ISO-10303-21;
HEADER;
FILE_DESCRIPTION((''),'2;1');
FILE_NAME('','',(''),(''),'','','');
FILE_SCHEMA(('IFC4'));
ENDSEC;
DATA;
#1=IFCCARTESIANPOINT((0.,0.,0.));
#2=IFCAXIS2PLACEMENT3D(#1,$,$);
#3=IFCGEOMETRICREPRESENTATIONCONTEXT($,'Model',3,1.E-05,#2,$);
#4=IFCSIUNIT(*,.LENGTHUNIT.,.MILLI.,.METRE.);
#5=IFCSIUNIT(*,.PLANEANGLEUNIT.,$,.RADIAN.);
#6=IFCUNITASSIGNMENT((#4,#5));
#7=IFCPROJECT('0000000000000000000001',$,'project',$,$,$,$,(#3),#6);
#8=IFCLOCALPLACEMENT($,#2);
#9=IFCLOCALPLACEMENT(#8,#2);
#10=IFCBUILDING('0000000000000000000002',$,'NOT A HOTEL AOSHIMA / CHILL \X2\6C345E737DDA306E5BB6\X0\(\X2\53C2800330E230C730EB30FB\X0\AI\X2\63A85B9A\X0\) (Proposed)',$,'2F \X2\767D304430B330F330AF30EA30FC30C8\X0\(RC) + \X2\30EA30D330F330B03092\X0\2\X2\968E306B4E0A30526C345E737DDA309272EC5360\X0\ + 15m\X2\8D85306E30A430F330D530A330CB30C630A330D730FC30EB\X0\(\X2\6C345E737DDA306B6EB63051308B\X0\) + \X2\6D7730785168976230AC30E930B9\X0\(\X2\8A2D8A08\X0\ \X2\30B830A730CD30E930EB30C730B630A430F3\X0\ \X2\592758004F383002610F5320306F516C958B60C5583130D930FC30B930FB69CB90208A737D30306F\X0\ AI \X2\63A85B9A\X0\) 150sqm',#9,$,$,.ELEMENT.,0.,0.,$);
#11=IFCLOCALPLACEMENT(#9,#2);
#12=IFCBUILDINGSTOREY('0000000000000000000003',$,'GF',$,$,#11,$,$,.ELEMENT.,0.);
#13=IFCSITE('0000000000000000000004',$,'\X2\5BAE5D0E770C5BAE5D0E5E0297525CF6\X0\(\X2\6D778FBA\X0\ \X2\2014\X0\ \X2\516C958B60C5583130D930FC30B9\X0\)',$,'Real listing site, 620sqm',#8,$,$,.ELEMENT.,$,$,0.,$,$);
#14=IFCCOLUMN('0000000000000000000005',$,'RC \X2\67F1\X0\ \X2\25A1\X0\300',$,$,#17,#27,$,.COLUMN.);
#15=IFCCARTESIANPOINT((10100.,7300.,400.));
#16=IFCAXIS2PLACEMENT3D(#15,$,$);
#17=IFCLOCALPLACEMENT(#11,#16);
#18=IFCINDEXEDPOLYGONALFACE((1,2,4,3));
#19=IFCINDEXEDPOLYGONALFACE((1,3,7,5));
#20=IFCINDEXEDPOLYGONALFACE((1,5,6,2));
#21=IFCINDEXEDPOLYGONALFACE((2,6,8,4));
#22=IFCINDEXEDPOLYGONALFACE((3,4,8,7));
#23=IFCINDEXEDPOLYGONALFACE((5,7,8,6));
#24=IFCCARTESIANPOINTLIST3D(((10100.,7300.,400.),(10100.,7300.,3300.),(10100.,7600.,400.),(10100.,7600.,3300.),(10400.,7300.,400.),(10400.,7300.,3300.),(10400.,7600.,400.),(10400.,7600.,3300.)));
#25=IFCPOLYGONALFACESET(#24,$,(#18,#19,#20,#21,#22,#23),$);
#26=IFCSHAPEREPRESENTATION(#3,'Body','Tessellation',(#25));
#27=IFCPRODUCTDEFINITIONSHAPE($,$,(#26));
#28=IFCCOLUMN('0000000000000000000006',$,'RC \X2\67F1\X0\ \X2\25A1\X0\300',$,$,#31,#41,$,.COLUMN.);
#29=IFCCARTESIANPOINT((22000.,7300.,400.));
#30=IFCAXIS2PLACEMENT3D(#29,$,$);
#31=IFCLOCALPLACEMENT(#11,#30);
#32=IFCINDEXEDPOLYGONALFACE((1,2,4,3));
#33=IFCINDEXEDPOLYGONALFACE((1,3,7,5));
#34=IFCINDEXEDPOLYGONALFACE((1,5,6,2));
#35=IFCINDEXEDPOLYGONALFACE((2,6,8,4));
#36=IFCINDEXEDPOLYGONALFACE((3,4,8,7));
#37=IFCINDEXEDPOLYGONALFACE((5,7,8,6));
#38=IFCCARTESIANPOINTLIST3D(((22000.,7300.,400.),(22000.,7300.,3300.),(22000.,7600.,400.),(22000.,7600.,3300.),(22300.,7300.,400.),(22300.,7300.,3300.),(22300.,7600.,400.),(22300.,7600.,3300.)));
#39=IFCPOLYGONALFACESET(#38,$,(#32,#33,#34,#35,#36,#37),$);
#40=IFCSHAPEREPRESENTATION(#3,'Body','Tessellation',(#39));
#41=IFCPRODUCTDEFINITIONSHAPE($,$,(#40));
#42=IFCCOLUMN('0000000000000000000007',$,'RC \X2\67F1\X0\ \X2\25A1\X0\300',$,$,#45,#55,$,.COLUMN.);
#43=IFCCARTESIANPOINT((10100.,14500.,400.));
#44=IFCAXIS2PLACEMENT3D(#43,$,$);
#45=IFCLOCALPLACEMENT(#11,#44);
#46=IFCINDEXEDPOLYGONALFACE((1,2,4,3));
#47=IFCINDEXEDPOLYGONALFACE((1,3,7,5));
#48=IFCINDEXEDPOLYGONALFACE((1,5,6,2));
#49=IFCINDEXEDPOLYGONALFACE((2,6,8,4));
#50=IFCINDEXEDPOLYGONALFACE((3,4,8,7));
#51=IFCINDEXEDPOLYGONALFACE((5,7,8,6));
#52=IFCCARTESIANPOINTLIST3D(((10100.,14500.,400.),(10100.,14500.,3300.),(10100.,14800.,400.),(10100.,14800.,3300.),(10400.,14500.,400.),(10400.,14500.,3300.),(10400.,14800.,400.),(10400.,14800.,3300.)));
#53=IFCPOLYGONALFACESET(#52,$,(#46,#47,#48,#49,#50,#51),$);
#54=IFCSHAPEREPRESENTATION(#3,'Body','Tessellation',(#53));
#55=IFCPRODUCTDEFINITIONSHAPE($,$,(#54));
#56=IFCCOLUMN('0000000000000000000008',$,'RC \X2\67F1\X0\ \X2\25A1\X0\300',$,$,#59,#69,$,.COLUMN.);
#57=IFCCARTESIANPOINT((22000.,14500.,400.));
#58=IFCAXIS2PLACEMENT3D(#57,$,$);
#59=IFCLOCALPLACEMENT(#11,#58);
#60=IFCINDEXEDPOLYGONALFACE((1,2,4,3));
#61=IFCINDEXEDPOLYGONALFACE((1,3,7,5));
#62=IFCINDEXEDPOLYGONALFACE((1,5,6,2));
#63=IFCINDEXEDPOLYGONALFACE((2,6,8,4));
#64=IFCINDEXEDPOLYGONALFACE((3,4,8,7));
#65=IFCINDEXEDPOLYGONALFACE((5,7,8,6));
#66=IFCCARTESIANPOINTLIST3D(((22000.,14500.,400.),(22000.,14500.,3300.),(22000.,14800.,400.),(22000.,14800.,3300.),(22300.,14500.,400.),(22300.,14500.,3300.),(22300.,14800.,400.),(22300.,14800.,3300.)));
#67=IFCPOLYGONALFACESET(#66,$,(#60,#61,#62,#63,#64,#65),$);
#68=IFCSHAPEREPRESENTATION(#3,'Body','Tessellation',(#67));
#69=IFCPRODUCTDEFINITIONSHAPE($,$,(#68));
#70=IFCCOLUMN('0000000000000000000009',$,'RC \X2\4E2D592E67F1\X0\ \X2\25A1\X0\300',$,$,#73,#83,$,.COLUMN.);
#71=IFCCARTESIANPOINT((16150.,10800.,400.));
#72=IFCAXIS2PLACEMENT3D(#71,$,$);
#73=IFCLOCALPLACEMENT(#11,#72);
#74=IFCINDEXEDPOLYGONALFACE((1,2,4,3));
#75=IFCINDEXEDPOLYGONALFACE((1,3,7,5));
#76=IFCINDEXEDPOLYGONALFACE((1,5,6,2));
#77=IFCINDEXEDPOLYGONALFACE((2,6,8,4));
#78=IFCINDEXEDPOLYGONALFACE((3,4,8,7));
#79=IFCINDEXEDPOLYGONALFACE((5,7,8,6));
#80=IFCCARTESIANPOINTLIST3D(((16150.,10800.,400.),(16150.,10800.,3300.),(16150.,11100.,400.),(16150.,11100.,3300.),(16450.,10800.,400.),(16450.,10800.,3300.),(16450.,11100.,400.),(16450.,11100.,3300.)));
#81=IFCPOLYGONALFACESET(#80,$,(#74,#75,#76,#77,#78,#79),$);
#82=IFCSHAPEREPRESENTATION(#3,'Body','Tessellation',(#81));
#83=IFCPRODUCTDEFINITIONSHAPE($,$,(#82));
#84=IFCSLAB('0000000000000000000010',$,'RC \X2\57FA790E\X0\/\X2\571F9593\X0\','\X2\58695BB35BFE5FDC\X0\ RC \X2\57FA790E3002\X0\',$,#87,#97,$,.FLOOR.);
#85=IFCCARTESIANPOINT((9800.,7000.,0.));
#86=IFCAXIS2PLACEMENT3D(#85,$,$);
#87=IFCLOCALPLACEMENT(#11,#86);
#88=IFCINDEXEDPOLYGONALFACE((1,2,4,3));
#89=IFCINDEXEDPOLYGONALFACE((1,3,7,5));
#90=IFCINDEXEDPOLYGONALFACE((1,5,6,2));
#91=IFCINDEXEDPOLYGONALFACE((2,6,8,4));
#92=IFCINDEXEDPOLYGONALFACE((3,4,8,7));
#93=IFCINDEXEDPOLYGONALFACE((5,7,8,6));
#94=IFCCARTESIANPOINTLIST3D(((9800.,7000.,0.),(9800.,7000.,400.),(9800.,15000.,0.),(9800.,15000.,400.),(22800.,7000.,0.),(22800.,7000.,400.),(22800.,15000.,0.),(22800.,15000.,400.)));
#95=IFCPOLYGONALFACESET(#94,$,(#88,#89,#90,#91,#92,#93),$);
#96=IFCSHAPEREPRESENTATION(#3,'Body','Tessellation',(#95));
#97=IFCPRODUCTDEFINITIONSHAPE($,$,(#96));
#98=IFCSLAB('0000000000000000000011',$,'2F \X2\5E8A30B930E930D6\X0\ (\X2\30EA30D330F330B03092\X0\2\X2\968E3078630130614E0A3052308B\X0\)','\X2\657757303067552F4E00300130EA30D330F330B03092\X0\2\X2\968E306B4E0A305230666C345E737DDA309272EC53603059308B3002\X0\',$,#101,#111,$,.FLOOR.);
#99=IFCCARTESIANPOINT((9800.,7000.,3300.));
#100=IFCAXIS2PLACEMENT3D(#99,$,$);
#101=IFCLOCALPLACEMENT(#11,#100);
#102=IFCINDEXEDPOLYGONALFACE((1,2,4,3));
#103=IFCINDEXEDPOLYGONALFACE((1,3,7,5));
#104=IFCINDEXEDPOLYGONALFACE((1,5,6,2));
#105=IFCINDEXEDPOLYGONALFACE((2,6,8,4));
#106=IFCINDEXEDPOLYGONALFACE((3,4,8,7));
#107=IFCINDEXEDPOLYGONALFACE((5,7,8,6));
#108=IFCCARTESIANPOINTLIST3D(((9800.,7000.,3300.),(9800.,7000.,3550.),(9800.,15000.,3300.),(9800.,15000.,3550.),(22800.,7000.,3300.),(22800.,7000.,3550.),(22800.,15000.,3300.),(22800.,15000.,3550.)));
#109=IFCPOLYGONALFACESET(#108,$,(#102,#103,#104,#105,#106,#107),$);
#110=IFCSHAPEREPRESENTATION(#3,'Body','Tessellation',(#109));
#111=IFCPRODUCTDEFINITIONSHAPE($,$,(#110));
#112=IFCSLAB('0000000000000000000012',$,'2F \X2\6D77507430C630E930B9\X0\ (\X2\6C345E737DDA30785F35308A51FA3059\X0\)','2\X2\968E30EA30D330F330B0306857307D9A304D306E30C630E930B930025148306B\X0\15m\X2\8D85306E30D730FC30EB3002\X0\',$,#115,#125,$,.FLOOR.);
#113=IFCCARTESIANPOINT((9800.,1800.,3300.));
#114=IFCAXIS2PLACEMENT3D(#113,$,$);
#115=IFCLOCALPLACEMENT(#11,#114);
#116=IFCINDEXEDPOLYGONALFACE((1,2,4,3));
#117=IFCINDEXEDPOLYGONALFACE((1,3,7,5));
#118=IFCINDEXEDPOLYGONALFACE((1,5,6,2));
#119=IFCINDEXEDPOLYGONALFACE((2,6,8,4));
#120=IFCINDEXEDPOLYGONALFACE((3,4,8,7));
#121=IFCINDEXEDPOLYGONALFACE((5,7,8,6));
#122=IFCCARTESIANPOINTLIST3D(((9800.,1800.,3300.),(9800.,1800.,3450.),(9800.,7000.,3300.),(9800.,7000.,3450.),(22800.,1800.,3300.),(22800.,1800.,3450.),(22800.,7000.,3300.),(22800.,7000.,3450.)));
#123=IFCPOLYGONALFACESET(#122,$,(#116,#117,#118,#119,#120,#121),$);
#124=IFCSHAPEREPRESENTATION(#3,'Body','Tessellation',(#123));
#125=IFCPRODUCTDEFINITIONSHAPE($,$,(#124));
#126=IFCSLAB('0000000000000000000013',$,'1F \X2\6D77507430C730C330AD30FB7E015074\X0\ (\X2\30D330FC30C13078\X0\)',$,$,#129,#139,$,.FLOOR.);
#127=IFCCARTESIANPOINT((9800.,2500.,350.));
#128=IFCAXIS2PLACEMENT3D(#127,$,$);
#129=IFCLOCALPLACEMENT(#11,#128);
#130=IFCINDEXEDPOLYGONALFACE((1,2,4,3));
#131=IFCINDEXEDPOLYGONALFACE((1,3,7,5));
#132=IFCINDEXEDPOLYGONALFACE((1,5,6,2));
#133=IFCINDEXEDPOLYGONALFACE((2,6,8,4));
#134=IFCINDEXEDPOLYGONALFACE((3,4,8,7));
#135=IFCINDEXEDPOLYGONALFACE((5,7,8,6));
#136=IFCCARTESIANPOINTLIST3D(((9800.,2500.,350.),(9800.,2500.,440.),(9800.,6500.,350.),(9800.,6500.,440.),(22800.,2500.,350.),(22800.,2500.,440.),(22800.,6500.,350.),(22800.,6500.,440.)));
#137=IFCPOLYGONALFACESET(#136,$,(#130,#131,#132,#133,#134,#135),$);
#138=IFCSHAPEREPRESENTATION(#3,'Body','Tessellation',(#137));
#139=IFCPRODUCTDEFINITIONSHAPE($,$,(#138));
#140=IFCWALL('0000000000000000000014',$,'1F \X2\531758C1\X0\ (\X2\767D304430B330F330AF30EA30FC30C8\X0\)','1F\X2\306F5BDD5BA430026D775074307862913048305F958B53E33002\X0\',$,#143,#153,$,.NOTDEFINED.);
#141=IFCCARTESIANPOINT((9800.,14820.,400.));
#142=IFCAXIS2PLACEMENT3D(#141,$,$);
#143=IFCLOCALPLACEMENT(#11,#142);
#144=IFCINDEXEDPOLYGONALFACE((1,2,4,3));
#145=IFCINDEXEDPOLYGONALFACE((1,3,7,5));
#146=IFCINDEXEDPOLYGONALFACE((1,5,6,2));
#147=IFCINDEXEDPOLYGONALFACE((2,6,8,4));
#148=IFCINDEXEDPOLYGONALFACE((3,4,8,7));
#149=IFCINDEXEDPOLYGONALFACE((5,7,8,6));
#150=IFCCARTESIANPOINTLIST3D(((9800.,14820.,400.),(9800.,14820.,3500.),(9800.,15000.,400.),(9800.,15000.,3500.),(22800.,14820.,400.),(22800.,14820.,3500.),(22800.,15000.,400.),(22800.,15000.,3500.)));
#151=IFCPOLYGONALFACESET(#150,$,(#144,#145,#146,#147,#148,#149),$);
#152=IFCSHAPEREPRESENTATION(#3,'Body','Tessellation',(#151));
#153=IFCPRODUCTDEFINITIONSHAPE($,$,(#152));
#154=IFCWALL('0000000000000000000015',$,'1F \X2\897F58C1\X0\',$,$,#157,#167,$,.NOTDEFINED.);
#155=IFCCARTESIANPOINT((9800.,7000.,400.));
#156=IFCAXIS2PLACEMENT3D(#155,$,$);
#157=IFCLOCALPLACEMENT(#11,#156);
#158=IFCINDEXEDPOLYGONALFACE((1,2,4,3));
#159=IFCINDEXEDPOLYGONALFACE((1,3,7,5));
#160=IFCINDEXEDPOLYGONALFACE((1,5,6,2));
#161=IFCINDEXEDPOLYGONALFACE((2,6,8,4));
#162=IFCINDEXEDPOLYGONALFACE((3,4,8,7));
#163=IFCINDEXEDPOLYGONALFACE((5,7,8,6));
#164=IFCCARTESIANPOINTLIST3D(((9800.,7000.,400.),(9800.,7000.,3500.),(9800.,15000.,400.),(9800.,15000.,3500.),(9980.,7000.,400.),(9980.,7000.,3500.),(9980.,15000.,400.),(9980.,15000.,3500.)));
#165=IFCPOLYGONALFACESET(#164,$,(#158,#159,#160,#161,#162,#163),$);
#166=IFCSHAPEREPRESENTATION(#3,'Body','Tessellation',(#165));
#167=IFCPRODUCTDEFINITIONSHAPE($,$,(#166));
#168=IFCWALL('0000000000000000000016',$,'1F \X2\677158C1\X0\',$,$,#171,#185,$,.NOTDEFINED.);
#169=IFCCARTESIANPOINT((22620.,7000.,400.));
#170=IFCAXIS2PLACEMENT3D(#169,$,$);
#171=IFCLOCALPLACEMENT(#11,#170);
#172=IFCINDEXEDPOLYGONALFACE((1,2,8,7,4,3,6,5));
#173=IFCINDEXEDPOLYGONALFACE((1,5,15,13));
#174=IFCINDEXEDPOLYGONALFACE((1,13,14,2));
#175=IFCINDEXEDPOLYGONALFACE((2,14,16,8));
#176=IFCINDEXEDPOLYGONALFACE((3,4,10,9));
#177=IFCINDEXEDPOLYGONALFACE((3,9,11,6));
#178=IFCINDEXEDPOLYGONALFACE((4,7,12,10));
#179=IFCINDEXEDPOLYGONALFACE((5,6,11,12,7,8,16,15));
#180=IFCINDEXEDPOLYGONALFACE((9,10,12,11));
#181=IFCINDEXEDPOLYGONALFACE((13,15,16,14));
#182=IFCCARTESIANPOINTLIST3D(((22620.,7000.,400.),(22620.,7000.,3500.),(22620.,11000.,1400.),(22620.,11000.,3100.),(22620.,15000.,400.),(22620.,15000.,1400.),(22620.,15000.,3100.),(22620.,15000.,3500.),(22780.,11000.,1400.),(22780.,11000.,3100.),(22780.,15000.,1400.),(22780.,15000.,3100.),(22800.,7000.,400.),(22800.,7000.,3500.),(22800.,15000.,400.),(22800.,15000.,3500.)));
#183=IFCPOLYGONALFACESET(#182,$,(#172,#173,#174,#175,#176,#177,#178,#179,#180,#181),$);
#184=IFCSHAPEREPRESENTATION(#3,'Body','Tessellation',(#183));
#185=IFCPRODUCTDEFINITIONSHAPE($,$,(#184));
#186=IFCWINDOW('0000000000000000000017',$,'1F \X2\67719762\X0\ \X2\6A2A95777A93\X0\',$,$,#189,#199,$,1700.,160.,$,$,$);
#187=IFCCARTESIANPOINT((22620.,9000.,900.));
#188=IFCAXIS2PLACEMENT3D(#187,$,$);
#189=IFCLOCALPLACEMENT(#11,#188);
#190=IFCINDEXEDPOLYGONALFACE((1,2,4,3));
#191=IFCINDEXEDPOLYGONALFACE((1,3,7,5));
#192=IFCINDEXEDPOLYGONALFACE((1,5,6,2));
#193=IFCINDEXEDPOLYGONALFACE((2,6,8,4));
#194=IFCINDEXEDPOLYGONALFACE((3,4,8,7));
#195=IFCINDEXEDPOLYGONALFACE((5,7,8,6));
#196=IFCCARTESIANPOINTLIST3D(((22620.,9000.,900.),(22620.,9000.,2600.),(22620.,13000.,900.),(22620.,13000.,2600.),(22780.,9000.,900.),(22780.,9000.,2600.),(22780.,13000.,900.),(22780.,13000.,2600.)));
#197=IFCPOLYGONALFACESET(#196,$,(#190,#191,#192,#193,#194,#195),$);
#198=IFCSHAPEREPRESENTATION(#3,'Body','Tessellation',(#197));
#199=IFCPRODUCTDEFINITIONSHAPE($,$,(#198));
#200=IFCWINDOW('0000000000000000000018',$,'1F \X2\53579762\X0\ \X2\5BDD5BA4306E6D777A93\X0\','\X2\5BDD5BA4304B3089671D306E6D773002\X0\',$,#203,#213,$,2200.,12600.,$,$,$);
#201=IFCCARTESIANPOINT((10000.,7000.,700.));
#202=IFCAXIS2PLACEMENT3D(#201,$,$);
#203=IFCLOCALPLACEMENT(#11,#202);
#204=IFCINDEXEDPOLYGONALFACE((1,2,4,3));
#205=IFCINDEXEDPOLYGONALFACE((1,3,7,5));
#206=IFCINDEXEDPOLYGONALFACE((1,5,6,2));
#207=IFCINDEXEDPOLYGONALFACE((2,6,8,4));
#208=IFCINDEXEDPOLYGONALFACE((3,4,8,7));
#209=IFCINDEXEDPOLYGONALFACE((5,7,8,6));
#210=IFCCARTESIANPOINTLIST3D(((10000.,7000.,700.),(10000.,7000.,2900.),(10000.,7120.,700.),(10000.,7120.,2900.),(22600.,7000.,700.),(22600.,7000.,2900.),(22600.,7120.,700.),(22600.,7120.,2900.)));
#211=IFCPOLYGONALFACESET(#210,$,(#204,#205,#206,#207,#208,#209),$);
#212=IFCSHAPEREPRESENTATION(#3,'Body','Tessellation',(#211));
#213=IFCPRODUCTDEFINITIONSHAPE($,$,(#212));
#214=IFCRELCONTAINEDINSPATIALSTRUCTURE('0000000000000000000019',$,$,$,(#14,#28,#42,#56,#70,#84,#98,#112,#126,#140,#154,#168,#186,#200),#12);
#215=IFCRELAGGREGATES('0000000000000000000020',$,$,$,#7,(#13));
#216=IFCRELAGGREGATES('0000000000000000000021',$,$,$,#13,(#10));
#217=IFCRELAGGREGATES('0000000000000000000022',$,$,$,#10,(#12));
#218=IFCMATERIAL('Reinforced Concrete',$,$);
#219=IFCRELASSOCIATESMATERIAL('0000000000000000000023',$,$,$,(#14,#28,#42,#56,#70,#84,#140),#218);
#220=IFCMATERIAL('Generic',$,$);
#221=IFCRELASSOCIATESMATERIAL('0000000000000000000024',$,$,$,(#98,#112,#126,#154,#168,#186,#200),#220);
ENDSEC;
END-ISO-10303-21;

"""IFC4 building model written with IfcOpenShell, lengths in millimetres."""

from ifc_helpers import new_model, si_unit, frame, frame_2d, origin, place, context, project, spatial, rectangle, extrude, material, element, fill, save


model = new_model("IFC4")

# Units and contexts
model_context = context("Model", 3, precision=1e-05, world=origin())
ifc_project = project(units=[si_unit("LENGTHUNIT", "METRE", prefix="MILLI"), si_unit("PLANEANGLEUNIT", "RADIAN")], contexts=[model_context])

# Site, building, storey
site_placement = place(None, origin())
site = spatial("IfcSite", under=ifc_project, at=site_placement, Name="宮崎県宮崎市青島(海辺 — 公開情報ベース)", ObjectType="Real listing site, 620sqm", CompositionType="ELEMENT", RefElevation=0.0)
building_placement = place(site_placement, origin())
building = spatial("IfcBuilding", under=site, at=building_placement, Name="NOT A HOTEL AOSHIMA / CHILL 水平線の家(参考モデル・AI推定) (Proposed)", ObjectType="2F 白いコンクリート(RC) + リビングを2階に上げ水平線を独占 + 15m超のインフィニティプール(水平線に溶ける) + 海へ全面ガラス(設計 ジェネラルデザイン 大堀伸。意匠は公開情報ベース・構造詳細は AI 推定) 150sqm", CompositionType="ELEMENT", ElevationOfRefHeight=0.0, ElevationOfTerrain=0.0)
storey_placement = place(building_placement, origin())
storey = spatial("IfcBuildingStorey", under=building, at=storey_placement, Name="GF", CompositionType="ELEMENT", Elevation=0.0)

# Columns
ifc_material_1 = material(Name="Reinforced Concrete")
column_1_placement = place(storey_placement, frame((10100.0, 7300.0, 400.0)))
element("IfcColumn", 1, at=column_1_placement, inside=storey, material=ifc_material_1, Name="RC 柱 □300", PredefinedType="COLUMN", context=model_context, shape_type="SweptSolid", body=[
    extrude(rectangle(XDim=300.0, YDim=300.0, at=frame_2d((150.0, 150.0))), frame((10100.0, 7300.0, 400.0)), (0.0, 0.0, 1.0), 2900.0),
])
column_2_placement = place(storey_placement, frame((22000.0, 7300.0, 400.0)))
element("IfcColumn", 2, at=column_2_placement, inside=storey, material=ifc_material_1, Name="RC 柱 □300", PredefinedType="COLUMN", context=model_context, shape_type="SweptSolid", body=[
    extrude(rectangle(XDim=300.0, YDim=300.0, at=frame_2d((150.0, 150.0))), frame((22000.0, 7300.0, 400.0)), (0.0, 0.0, 1.0), 2900.0),
])
column_3_placement = place(storey_placement, frame((10100.0, 14500.0, 400.0)))
element("IfcColumn", 3, at=column_3_placement, inside=storey, material=ifc_material_1, Name="RC 柱 □300", PredefinedType="COLUMN", context=model_context, shape_type="SweptSolid", body=[
    extrude(rectangle(XDim=300.0, YDim=300.0, at=frame_2d((150.0, 150.0))), frame((10100.0, 14500.0, 400.0)), (0.0, 0.0, 1.0), 2900.0),
])
column_4_placement = place(storey_placement, frame((22000.0, 14500.0, 400.0)))
element("IfcColumn", 4, at=column_4_placement, inside=storey, material=ifc_material_1, Name="RC 柱 □300", PredefinedType="COLUMN", context=model_context, shape_type="SweptSolid", body=[
    extrude(rectangle(XDim=300.0, YDim=300.0, at=frame_2d((150.0, 150.0))), frame((22000.0, 14500.0, 400.0)), (0.0, 0.0, 1.0), 2900.0),
])
column_5_placement = place(storey_placement, frame((16150.0, 10800.0, 400.0)))
element("IfcColumn", 5, at=column_5_placement, inside=storey, material=ifc_material_1, Name="RC 中央柱 □300", PredefinedType="COLUMN", context=model_context, shape_type="SweptSolid", body=[
    extrude(rectangle(XDim=300.0, YDim=300.0, at=frame_2d((150.0, 150.0))), frame((16150.0, 10800.0, 400.0)), (0.0, 0.0, 1.0), 2900.0),
])

# Slabs
slab_1_placement = place(storey_placement, frame((9800.0, 7000.0, 0.0)))
element("IfcSlab", 6, at=slab_1_placement, inside=storey, material=ifc_material_1, Name="RC 基礎/土間", Description="塩害対応 RC 基礎。", PredefinedType="FLOOR", context=model_context, shape_type="SweptSolid", body=[
    extrude(rectangle(XDim=13000.0, YDim=8000.0, at=frame_2d((6500.0, 4000.0))), frame((9800.0, 7000.0, 0.0)), (0.0, 0.0, 1.0), 400.0),
])
ifc_material_2 = material(Name="Generic")
slab_2_placement = place(storey_placement, frame((9800.0, 7000.0, 3300.0)))
element("IfcSlab", 7, at=slab_2_placement, inside=storey, material=ifc_material_2, Name="2F 床スラブ (リビングを2階へ持ち上げる)", Description="敷地で唯一、リビングを2階に上げて水平線を独占する。", PredefinedType="FLOOR", context=model_context, shape_type="SweptSolid", body=[
    extrude(rectangle(XDim=13000.0, YDim=8000.0, at=frame_2d((6500.0, 4000.0))), frame((9800.0, 7000.0, 3300.0)), (0.0, 0.0, 1.0), 250.0),
])
slab_3_placement = place(storey_placement, frame((9800.0, 1800.0, 3300.0)))
element("IfcSlab", 8, at=slab_3_placement, inside=storey, material=ifc_material_2, Name="2F 海側テラス (水平線へ張り出す)", Description="2階リビングと地続きのテラス。先に15m超のプール。", PredefinedType="FLOOR", context=model_context, shape_type="SweptSolid", body=[
    extrude(rectangle(XDim=13000.0, YDim=5200.0, at=frame_2d((6500.0, 2600.0))), frame((9800.0, 1800.0, 3300.0)), (0.0, 0.0, 1.0), 150.0),
])
slab_4_placement = place(storey_placement, frame((9800.0, 2500.0, 350.0)))
element("IfcSlab", 9, at=slab_4_placement, inside=storey, material=ifc_material_2, Name="1F 海側デッキ・縁側 (ビーチへ)", PredefinedType="FLOOR", context=model_context, shape_type="SweptSolid", body=[
    extrude(rectangle(XDim=13000.0, YDim=4000.0, at=frame_2d((6500.0, 2000.0))), frame((9800.0, 2500.0, 350.0)), (0.0, 0.0, 1.0), 90.0),
])

# Walls
wall_1_placement = place(storey_placement, frame((9800.0, 14820.0, 400.0)))
element("IfcWall", 10, at=wall_1_placement, inside=storey, material=ifc_material_1, Name="1F 北壁 (白いコンクリート)", Description="1Fは寝室。海側へ抑えた開口。", PredefinedType="NOTDEFINED", context=model_context, shape_type="SweptSolid", body=[
    extrude(rectangle(XDim=13000.0, YDim=180.0, at=frame_2d((6500.0, 90.0))), frame((9800.0, 14820.0, 400.0)), (0.0, 0.0, 1.0), 3100.0),
])
wall_2_placement = place(storey_placement, frame((9800.0, 7000.0, 400.0)))
element("IfcWall", 11, at=wall_2_placement, inside=storey, material=ifc_material_2, Name="1F 西壁", PredefinedType="NOTDEFINED", context=model_context, shape_type="SweptSolid", body=[
    extrude(rectangle(XDim=180.0, YDim=8000.0, at=frame_2d((90.0, 4000.0))), frame((9800.0, 7000.0, 400.0)), (0.0, 0.0, 1.0), 3100.0),
])

# Wall, opening, window
wall_3_placement = place(storey_placement, frame((22620.0, 7000.0, 400.0)))
wall_3 = element("IfcWall", 12, at=wall_3_placement, inside=storey, material=ifc_material_2, Name="1F 東壁", PredefinedType="NOTDEFINED", context=model_context, shape_type="SweptSolid", body=[
    extrude(rectangle(XDim=180.0, YDim=8000.0, at=frame_2d((90.0, 4000.0))), frame((22620.0, 7000.0, 400.0)), (0.0, 0.0, 1.0), 3100.0),
])
opening_placement = place(storey_placement, frame((22620.0, 9000.0, 900.0)))
opening = element("IfcOpeningElement", 13, at=opening_placement, cuts=wall_3, PredefinedType="NOTDEFINED", context=model_context, shape_type="SweptSolid", body=[
    extrude(rectangle(XDim=160.0, YDim=4000.0, at=frame_2d((80.0, 2000.0))), frame((22620.0, 9000.0, 900.0)), (0.0, 0.0, 1.0), 1700.0),
])
window_1_placement = place(storey_placement, frame((22620.0, 9000.0, 900.0)))
window_1 = element("IfcWindow", 14, at=window_1_placement, inside=storey, material=ifc_material_2, Name="1F 東面 横長窓", OverallHeight=1700.0, OverallWidth=160.0, context=model_context, shape_type="SweptSolid", body=[
    extrude(rectangle(XDim=160.0, YDim=4000.0, at=frame_2d((80.0, 2000.0))), frame((22620.0, 9000.0, 900.0)), (0.0, 0.0, 1.0), 1700.0),
])
fill(opening, window_1)

# Window
window_2_placement = place(storey_placement, frame((10000.0, 7000.0, 700.0)))
element("IfcWindow", 15, at=window_2_placement, inside=storey, material=ifc_material_2, Name="1F 南面 寝室の海窓", Description="寝室から朝の海。", OverallHeight=2200.0, OverallWidth=12600.0, context=model_context, shape_type="SweptSolid", body=[
    extrude(rectangle(XDim=12600.0, YDim=120.0, at=frame_2d((6300.0, 60.0))), frame((10000.0, 7000.0, 700.0)), (0.0, 0.0, 1.0), 2200.0),
])

save(model, "model.ifc")
